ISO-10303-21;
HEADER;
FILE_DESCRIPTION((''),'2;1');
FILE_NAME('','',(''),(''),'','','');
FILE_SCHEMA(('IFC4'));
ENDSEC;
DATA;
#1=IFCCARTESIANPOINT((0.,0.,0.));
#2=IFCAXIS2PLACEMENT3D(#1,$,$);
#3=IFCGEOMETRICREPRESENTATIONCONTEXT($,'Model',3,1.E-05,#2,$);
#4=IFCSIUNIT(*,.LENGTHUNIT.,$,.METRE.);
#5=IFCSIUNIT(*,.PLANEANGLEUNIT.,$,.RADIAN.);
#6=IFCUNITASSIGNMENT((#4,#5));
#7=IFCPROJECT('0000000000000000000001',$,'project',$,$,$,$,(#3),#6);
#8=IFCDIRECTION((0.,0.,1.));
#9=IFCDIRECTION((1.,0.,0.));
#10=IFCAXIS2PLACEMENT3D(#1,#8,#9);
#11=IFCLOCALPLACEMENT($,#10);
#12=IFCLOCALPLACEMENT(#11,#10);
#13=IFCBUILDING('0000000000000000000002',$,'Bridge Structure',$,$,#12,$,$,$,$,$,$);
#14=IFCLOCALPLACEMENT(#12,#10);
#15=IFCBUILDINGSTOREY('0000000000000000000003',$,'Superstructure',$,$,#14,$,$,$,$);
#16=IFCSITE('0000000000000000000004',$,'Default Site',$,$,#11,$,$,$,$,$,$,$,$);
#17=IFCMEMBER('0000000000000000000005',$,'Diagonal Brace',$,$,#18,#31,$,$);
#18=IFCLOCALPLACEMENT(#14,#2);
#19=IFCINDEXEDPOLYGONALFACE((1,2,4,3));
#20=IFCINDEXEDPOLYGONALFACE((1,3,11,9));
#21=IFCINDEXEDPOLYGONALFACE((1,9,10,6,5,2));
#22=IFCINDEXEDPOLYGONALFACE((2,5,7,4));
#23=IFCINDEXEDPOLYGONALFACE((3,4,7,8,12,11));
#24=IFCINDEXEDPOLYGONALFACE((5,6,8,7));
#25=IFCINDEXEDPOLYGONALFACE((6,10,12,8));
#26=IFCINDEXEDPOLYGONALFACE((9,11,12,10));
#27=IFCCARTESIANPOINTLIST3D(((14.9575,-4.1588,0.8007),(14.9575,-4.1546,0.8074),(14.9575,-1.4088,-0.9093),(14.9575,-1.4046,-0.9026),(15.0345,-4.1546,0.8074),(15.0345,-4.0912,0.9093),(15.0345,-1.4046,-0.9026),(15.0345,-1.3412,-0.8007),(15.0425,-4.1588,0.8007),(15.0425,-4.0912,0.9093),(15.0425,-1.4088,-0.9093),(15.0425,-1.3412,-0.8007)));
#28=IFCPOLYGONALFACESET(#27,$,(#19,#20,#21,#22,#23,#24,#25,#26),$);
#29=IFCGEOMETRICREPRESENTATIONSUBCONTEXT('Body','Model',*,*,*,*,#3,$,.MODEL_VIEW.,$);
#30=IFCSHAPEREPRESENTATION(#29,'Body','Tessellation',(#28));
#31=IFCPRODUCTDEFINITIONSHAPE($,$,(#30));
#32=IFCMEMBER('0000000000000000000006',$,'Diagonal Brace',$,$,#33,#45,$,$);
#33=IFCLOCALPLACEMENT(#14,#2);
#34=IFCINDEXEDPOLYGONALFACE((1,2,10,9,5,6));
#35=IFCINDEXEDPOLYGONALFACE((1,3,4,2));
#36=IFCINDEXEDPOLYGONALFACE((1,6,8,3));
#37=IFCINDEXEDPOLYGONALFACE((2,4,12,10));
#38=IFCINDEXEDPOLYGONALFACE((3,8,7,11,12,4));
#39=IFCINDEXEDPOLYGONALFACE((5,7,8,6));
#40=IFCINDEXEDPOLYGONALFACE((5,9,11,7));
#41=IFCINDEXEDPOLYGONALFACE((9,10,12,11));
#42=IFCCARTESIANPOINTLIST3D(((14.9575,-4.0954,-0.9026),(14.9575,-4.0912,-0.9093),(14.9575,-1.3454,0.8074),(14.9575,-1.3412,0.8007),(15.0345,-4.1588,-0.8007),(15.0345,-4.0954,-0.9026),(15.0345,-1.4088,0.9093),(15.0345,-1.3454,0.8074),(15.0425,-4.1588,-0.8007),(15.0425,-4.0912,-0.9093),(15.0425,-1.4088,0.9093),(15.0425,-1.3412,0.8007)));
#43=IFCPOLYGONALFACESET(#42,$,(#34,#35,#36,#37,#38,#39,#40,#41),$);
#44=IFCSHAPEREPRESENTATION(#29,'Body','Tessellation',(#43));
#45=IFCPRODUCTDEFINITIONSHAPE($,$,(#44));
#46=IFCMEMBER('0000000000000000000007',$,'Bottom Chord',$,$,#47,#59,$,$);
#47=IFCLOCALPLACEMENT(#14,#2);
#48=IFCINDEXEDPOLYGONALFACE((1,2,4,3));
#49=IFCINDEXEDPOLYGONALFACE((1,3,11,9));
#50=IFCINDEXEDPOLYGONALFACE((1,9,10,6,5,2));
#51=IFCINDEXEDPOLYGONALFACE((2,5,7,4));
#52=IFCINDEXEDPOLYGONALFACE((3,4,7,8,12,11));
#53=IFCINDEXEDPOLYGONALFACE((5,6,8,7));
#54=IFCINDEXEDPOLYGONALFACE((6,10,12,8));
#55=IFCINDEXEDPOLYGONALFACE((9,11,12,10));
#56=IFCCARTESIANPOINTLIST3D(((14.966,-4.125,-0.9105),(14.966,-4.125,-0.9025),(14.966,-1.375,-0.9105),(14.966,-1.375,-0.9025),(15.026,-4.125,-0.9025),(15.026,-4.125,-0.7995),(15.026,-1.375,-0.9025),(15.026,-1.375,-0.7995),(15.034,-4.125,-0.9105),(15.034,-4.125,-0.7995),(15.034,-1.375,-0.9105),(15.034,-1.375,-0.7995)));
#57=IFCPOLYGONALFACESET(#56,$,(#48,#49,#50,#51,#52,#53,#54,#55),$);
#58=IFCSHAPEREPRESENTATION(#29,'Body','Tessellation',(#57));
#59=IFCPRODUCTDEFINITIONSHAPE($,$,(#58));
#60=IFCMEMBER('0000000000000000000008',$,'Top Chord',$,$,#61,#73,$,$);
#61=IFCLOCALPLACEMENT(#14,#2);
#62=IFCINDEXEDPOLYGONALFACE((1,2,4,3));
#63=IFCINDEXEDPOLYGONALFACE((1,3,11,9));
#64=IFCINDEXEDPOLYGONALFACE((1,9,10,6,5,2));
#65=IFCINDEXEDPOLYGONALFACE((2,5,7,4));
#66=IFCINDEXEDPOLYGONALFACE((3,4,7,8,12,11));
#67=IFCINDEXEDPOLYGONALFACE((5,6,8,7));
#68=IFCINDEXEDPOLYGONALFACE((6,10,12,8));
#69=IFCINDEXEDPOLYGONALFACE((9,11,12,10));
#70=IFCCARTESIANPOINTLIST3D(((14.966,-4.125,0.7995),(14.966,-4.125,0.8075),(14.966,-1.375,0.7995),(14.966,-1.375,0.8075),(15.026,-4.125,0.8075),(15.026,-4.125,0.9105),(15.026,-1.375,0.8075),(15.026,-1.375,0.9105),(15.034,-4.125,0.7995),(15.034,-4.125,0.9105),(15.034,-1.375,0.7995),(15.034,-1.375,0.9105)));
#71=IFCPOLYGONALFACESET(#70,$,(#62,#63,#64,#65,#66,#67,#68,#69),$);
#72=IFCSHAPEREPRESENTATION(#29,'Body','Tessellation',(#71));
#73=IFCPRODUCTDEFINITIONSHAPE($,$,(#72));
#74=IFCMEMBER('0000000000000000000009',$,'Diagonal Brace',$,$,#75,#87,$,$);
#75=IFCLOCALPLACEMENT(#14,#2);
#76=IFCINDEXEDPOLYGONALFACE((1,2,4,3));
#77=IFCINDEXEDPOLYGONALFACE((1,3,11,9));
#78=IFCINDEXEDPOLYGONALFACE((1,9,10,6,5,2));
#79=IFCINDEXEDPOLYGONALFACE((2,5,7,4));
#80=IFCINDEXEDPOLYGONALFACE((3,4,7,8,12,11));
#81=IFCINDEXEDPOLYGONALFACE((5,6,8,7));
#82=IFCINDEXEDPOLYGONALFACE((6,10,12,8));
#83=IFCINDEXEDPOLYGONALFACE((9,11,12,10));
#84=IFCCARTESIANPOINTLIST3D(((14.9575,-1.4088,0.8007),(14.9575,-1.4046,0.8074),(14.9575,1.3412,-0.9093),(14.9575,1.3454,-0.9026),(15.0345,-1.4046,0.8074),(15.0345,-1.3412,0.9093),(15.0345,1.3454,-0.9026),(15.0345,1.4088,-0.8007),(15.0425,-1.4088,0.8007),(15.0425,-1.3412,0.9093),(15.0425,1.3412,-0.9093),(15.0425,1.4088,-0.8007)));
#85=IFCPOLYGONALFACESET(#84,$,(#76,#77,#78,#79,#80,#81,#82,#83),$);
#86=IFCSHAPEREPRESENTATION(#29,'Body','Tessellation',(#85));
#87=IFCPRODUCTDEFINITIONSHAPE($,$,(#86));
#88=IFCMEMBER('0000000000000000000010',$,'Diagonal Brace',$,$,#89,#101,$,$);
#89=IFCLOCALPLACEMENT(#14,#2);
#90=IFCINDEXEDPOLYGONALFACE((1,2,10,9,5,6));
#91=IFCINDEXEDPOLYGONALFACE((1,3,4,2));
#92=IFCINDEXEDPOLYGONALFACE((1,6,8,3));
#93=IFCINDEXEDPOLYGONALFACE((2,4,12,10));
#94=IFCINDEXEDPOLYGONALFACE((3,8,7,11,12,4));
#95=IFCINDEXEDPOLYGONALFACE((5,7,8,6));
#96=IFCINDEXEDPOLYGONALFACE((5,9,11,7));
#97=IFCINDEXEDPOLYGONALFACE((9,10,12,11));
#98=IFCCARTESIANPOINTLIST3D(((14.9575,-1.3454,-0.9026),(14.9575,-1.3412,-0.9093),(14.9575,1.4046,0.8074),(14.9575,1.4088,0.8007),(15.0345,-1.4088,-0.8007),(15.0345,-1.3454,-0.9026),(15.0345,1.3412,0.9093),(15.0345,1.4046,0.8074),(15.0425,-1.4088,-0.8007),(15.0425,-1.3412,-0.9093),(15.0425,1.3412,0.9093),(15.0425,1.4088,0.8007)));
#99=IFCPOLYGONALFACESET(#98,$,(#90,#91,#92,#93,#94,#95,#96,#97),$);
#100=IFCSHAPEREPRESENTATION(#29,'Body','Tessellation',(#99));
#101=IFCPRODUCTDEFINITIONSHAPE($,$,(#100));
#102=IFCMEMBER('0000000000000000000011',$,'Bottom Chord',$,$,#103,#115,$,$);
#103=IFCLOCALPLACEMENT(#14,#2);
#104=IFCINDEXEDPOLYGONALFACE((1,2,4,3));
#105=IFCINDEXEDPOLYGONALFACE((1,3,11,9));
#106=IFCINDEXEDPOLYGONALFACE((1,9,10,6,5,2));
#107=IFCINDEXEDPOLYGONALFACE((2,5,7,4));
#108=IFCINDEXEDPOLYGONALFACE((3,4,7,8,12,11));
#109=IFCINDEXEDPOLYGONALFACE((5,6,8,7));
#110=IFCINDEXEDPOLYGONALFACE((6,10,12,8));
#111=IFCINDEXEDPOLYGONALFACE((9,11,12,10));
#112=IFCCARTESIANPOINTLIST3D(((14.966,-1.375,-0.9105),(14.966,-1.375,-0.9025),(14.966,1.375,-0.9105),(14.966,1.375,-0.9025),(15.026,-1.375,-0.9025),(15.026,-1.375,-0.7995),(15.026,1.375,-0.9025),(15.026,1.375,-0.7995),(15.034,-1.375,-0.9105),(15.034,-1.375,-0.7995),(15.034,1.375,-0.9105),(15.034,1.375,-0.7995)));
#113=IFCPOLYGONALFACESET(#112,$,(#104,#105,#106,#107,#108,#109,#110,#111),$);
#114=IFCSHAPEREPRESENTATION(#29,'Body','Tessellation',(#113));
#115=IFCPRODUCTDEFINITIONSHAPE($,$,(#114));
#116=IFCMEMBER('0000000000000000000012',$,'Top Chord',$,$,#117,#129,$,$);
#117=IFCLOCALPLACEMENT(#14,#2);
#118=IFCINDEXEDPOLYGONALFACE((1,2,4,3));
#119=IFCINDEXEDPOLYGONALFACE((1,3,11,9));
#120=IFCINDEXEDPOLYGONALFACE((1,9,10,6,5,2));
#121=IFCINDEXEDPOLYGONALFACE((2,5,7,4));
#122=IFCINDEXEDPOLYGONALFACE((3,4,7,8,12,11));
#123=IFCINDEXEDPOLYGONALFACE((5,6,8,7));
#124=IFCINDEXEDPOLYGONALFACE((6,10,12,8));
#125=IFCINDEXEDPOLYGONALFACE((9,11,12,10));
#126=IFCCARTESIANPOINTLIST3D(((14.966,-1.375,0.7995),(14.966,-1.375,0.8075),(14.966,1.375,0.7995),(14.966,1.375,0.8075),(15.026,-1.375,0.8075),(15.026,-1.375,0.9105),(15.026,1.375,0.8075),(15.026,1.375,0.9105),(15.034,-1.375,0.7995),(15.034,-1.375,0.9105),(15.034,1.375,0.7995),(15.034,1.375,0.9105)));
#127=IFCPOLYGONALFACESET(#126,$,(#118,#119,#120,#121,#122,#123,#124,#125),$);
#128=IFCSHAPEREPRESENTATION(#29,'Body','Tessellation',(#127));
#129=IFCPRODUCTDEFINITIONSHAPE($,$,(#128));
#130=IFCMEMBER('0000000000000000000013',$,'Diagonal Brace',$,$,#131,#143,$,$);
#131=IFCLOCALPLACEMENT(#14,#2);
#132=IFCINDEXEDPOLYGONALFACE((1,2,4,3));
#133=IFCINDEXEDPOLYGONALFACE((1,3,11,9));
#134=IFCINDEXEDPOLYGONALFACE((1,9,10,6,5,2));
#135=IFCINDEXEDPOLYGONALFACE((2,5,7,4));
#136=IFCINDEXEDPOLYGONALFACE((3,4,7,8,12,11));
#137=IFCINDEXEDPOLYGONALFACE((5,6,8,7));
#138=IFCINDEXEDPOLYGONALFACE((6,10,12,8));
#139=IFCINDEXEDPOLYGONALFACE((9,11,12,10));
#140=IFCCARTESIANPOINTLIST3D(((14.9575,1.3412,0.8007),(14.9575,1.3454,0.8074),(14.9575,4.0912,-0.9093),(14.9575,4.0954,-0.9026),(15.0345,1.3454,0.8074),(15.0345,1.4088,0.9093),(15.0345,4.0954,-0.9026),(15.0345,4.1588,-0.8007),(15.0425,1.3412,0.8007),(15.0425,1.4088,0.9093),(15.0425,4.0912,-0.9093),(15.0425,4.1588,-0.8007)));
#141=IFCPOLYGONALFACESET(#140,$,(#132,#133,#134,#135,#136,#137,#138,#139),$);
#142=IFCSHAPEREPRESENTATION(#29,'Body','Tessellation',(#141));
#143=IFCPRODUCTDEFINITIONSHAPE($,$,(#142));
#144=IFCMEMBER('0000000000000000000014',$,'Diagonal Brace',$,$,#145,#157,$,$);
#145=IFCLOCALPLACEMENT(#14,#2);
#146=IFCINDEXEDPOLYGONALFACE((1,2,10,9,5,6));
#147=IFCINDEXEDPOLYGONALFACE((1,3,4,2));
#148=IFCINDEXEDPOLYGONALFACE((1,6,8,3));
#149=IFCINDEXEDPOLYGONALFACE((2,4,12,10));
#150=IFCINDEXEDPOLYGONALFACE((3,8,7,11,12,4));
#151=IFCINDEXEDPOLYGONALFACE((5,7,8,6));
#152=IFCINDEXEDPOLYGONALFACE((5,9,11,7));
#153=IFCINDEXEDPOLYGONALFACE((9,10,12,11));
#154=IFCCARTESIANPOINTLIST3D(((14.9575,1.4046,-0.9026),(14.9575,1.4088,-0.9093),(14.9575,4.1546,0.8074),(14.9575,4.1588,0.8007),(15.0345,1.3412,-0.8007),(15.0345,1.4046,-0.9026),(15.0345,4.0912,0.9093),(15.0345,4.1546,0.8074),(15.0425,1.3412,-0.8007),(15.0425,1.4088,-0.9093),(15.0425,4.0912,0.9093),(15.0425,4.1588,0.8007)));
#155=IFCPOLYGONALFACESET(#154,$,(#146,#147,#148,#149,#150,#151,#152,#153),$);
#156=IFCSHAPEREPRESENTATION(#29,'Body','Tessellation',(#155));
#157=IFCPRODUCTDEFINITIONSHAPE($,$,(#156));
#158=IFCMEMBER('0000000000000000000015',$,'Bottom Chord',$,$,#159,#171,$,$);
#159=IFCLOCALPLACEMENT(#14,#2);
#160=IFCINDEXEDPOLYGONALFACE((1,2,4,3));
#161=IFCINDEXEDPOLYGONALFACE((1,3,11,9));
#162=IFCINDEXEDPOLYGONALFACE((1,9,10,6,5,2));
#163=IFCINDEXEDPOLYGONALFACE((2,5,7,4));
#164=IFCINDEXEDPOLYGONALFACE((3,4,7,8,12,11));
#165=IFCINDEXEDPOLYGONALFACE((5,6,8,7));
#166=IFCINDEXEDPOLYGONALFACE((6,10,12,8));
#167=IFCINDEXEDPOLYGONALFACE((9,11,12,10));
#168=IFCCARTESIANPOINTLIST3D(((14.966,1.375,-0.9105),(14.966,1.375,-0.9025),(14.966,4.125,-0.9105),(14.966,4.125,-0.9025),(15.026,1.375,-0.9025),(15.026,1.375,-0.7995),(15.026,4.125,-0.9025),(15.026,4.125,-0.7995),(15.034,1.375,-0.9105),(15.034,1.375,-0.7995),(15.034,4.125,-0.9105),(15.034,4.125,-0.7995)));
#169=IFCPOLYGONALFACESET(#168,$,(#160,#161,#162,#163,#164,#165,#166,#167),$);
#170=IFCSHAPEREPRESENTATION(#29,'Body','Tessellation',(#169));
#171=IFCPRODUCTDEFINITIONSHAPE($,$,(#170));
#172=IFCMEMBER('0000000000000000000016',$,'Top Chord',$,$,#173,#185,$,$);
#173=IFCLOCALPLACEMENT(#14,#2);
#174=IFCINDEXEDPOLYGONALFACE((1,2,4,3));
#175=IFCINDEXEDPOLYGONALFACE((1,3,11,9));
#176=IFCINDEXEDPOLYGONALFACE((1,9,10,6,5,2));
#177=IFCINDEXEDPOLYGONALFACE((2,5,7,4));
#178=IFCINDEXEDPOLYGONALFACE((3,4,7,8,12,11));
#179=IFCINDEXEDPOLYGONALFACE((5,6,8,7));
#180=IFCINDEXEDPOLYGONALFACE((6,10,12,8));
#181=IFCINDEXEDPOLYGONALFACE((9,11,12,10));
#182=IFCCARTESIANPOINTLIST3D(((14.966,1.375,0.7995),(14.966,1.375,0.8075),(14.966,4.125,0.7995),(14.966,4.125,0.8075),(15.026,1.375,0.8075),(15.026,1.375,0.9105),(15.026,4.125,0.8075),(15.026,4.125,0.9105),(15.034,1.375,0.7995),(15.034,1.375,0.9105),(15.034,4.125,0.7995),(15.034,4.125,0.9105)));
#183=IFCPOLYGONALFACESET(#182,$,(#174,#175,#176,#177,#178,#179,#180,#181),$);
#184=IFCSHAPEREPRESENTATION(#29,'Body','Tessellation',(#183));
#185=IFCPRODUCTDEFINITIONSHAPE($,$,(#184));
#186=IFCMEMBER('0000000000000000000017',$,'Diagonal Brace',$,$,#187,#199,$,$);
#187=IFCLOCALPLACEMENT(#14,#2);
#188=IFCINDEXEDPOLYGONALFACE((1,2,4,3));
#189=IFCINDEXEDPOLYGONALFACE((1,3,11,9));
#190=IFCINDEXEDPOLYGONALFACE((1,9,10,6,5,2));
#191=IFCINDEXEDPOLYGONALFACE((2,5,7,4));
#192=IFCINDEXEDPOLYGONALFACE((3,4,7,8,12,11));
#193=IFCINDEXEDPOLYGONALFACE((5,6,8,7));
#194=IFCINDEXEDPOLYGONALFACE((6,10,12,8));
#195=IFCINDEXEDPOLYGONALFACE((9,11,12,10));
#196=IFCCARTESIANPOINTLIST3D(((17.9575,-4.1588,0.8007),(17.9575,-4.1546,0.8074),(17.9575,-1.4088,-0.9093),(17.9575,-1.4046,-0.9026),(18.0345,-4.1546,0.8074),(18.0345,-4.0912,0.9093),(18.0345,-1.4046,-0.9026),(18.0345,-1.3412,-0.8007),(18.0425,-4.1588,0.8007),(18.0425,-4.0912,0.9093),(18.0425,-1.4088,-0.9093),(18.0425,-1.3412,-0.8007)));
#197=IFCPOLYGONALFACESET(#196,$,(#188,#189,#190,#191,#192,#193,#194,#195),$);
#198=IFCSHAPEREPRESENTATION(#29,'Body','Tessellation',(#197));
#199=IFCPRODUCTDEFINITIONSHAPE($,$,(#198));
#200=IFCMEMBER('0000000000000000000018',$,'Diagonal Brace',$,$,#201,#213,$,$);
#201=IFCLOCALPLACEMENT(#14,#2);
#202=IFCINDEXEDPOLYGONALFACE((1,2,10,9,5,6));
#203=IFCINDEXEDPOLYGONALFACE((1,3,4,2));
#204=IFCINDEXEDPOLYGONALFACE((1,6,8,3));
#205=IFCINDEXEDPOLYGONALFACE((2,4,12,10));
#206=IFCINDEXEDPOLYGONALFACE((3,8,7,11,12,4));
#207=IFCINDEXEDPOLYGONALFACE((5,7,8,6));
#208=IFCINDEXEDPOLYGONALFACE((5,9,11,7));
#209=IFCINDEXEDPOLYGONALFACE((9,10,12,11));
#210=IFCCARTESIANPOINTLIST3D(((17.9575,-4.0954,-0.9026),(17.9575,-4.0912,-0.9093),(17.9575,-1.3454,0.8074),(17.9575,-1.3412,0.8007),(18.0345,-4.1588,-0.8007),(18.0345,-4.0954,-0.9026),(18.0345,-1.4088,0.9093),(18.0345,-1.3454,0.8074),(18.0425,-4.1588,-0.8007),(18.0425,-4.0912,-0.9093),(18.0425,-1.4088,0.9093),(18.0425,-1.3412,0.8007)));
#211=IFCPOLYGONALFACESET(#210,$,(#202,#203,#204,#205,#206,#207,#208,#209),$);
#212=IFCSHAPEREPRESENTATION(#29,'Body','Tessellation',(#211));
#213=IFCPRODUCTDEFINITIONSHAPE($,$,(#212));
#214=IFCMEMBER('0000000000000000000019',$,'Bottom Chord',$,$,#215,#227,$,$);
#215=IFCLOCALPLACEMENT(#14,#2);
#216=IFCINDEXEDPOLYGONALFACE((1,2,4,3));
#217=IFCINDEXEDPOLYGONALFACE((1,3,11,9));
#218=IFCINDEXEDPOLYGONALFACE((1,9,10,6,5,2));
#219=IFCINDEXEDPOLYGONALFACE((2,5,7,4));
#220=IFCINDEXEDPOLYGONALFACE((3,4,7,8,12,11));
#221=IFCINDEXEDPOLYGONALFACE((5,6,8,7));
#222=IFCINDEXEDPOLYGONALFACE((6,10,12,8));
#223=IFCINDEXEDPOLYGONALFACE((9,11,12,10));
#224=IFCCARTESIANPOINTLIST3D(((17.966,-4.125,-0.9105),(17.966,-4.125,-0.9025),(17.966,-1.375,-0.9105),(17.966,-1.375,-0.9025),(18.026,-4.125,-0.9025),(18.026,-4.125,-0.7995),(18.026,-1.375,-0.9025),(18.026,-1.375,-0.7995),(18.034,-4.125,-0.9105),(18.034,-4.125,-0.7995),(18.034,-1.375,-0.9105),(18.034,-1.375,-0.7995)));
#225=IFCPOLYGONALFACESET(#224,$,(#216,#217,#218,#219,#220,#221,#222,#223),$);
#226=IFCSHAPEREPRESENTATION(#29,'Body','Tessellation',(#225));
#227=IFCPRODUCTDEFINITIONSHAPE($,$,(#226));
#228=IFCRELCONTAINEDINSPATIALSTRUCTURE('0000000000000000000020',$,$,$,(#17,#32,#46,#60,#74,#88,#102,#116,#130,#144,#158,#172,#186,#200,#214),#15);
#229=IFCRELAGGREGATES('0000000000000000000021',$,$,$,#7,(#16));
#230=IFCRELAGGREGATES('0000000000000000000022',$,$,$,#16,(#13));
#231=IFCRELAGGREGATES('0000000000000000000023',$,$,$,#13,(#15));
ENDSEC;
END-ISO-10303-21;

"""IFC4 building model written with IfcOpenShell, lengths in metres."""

from ifc_helpers import new_model, si_unit, frame, origin, origin_with_axes, origin_2d_with_axis, place, context, subcontext, project, spatial, l_section, extrude, element, save


model = new_model("IFC4")

# Units and contexts
model_context = context("Model", 3, precision=1e-05, world=origin())
body_context = subcontext(model_context, "Body", "Model", "MODEL_VIEW")
ifc_project = project(units=[si_unit("LENGTHUNIT", "METRE"), si_unit("PLANEANGLEUNIT", "RADIAN")], contexts=[model_context])

# Site, building, storey
site_placement = place(None, origin_with_axes())
site = spatial("IfcSite", under=ifc_project, at=site_placement, Name="Default Site")
building_placement = place(site_placement, origin_with_axes())
building = spatial("IfcBuilding", under=site, at=building_placement, Name="Bridge Structure")
storey_placement = place(building_placement, origin_with_axes())
storey = spatial("IfcBuildingStorey", under=building, at=storey_placement, Name="Superstructure")

# Members
for number, where, z_axis, x_axis, name in (
    (1, (15.0, -4.125, 0.855), (0.0, 0.84921, -0.528055), (-1.0, 0.0, 0.0), "Diagonal Brace"),
    (2, (15.0, -4.125, -0.855), (0.0, 0.84921, 0.528055), (-1.0, 0.0, 0.0), "Diagonal Brace"),
):
    element("IfcMember", number, at=place(storey_placement, frame(where, z_axis=z_axis, x_axis=x_axis)), inside=storey, Name=name, context=body_context, shape_type="SweptSolid", body=[
        extrude(l_section(Depth=0.128, Width=0.085, Thickness=0.008, at=origin_2d_with_axis()), origin_with_axes(), (0.0, 0.0, 1.0), 3.2383),
    ])
for number, where, z_axis, x_axis, name in (
    (3, (15.0, -4.125, -0.855), (0.0, 1.0, 0.0), (-1.0, 0.0, 0.0), "Bottom Chord"),
    (4, (15.0, -4.125, 0.855), (0.0, 1.0, 0.0), (-1.0, 0.0, 0.0), "Top Chord"),
):
    element("IfcMember", number, at=place(storey_placement, frame(where, z_axis=z_axis, x_axis=x_axis)), inside=storey, Name=name, context=body_context, shape_type="SweptSolid", body=[
        extrude(l_section(Depth=0.111, Width=0.068, Thickness=0.008, at=origin_2d_with_axis()), origin_with_axes(), (0.0, 0.0, 1.0), 2.75),
    ])
for number, where, z_axis, x_axis, name in (
    (5, (15.0, -1.375, 0.855), (0.0, 0.84921, -0.528055), (-1.0, 0.0, 0.0), "Diagonal Brace"),
    (6, (15.0, -1.375, -0.855), (0.0, 0.84921, 0.528055), (-1.0, 0.0, 0.0), "Diagonal Brace"),
):
    element("IfcMember", number, at=place(storey_placement, frame(where, z_axis=z_axis, x_axis=x_axis)), inside=storey, Name=name, context=body_context, shape_type="SweptSolid", body=[
        extrude(l_section(Depth=0.128, Width=0.085, Thickness=0.008, at=origin_2d_with_axis()), origin_with_axes(), (0.0, 0.0, 1.0), 3.2383),
    ])
for number, where, z_axis, x_axis, name in (
    (7, (15.0, -1.375, -0.855), (0.0, 1.0, 0.0), (-1.0, 0.0, 0.0), "Bottom Chord"),
    (8, (15.0, -1.375, 0.855), (0.0, 1.0, 0.0), (-1.0, 0.0, 0.0), "Top Chord"),
):
    element("IfcMember", number, at=place(storey_placement, frame(where, z_axis=z_axis, x_axis=x_axis)), inside=storey, Name=name, context=body_context, shape_type="SweptSolid", body=[
        extrude(l_section(Depth=0.111, Width=0.068, Thickness=0.008, at=origin_2d_with_axis()), origin_with_axes(), (0.0, 0.0, 1.0), 2.75),
    ])
for number, where, z_axis, x_axis, name in (
    (9, (15.0, 1.375, 0.855), (0.0, 0.84921, -0.528055), (-1.0, 0.0, 0.0), "Diagonal Brace"),
    (10, (15.0, 1.375, -0.855), (0.0, 0.84921, 0.528055), (-1.0, 0.0, 0.0), "Diagonal Brace"),
):
    element("IfcMember", number, at=place(storey_placement, frame(where, z_axis=z_axis, x_axis=x_axis)), inside=storey, Name=name, context=body_context, shape_type="SweptSolid", body=[
        extrude(l_section(Depth=0.128, Width=0.085, Thickness=0.008, at=origin_2d_with_axis()), origin_with_axes(), (0.0, 0.0, 1.0), 3.2383),
    ])
for number, where, z_axis, x_axis, name in (
    (11, (15.0, 1.375, -0.855), (0.0, 1.0, 0.0), (-1.0, 0.0, 0.0), "Bottom Chord"),
    (12, (15.0, 1.375, 0.855), (0.0, 1.0, 0.0), (-1.0, 0.0, 0.0), "Top Chord"),
):
    element("IfcMember", number, at=place(storey_placement, frame(where, z_axis=z_axis, x_axis=x_axis)), inside=storey, Name=name, context=body_context, shape_type="SweptSolid", body=[
        extrude(l_section(Depth=0.111, Width=0.068, Thickness=0.008, at=origin_2d_with_axis()), origin_with_axes(), (0.0, 0.0, 1.0), 2.75),
    ])
for number, where, z_axis, x_axis, name in (
    (13, (18.0, -4.125, 0.855), (0.0, 0.84921, -0.528055), (-1.0, 0.0, 0.0), "Diagonal Brace"),
    (14, (18.0, -4.125, -0.855), (0.0, 0.84921, 0.528055), (-1.0, 0.0, 0.0), "Diagonal Brace"),
):
    element("IfcMember", number, at=place(storey_placement, frame(where, z_axis=z_axis, x_axis=x_axis)), inside=storey, Name=name, context=body_context, shape_type="SweptSolid", body=[
        extrude(l_section(Depth=0.128, Width=0.085, Thickness=0.008, at=origin_2d_with_axis()), origin_with_axes(), (0.0, 0.0, 1.0), 3.2383),
    ])
for number, where, z_axis, x_axis, name in (
    (15, (18.0, -4.125, -0.855), (0.0, 1.0, 0.0), (-1.0, 0.0, 0.0), "Bottom Chord"),
):
    element("IfcMember", number, at=place(storey_placement, frame(where, z_axis=z_axis, x_axis=x_axis)), inside=storey, Name=name, context=body_context, shape_type="SweptSolid", body=[
        extrude(l_section(Depth=0.111, Width=0.068, Thickness=0.008, at=origin_2d_with_axis()), origin_with_axes(), (0.0, 0.0, 1.0), 2.75),
    ])

save(model, "model.ifc")
